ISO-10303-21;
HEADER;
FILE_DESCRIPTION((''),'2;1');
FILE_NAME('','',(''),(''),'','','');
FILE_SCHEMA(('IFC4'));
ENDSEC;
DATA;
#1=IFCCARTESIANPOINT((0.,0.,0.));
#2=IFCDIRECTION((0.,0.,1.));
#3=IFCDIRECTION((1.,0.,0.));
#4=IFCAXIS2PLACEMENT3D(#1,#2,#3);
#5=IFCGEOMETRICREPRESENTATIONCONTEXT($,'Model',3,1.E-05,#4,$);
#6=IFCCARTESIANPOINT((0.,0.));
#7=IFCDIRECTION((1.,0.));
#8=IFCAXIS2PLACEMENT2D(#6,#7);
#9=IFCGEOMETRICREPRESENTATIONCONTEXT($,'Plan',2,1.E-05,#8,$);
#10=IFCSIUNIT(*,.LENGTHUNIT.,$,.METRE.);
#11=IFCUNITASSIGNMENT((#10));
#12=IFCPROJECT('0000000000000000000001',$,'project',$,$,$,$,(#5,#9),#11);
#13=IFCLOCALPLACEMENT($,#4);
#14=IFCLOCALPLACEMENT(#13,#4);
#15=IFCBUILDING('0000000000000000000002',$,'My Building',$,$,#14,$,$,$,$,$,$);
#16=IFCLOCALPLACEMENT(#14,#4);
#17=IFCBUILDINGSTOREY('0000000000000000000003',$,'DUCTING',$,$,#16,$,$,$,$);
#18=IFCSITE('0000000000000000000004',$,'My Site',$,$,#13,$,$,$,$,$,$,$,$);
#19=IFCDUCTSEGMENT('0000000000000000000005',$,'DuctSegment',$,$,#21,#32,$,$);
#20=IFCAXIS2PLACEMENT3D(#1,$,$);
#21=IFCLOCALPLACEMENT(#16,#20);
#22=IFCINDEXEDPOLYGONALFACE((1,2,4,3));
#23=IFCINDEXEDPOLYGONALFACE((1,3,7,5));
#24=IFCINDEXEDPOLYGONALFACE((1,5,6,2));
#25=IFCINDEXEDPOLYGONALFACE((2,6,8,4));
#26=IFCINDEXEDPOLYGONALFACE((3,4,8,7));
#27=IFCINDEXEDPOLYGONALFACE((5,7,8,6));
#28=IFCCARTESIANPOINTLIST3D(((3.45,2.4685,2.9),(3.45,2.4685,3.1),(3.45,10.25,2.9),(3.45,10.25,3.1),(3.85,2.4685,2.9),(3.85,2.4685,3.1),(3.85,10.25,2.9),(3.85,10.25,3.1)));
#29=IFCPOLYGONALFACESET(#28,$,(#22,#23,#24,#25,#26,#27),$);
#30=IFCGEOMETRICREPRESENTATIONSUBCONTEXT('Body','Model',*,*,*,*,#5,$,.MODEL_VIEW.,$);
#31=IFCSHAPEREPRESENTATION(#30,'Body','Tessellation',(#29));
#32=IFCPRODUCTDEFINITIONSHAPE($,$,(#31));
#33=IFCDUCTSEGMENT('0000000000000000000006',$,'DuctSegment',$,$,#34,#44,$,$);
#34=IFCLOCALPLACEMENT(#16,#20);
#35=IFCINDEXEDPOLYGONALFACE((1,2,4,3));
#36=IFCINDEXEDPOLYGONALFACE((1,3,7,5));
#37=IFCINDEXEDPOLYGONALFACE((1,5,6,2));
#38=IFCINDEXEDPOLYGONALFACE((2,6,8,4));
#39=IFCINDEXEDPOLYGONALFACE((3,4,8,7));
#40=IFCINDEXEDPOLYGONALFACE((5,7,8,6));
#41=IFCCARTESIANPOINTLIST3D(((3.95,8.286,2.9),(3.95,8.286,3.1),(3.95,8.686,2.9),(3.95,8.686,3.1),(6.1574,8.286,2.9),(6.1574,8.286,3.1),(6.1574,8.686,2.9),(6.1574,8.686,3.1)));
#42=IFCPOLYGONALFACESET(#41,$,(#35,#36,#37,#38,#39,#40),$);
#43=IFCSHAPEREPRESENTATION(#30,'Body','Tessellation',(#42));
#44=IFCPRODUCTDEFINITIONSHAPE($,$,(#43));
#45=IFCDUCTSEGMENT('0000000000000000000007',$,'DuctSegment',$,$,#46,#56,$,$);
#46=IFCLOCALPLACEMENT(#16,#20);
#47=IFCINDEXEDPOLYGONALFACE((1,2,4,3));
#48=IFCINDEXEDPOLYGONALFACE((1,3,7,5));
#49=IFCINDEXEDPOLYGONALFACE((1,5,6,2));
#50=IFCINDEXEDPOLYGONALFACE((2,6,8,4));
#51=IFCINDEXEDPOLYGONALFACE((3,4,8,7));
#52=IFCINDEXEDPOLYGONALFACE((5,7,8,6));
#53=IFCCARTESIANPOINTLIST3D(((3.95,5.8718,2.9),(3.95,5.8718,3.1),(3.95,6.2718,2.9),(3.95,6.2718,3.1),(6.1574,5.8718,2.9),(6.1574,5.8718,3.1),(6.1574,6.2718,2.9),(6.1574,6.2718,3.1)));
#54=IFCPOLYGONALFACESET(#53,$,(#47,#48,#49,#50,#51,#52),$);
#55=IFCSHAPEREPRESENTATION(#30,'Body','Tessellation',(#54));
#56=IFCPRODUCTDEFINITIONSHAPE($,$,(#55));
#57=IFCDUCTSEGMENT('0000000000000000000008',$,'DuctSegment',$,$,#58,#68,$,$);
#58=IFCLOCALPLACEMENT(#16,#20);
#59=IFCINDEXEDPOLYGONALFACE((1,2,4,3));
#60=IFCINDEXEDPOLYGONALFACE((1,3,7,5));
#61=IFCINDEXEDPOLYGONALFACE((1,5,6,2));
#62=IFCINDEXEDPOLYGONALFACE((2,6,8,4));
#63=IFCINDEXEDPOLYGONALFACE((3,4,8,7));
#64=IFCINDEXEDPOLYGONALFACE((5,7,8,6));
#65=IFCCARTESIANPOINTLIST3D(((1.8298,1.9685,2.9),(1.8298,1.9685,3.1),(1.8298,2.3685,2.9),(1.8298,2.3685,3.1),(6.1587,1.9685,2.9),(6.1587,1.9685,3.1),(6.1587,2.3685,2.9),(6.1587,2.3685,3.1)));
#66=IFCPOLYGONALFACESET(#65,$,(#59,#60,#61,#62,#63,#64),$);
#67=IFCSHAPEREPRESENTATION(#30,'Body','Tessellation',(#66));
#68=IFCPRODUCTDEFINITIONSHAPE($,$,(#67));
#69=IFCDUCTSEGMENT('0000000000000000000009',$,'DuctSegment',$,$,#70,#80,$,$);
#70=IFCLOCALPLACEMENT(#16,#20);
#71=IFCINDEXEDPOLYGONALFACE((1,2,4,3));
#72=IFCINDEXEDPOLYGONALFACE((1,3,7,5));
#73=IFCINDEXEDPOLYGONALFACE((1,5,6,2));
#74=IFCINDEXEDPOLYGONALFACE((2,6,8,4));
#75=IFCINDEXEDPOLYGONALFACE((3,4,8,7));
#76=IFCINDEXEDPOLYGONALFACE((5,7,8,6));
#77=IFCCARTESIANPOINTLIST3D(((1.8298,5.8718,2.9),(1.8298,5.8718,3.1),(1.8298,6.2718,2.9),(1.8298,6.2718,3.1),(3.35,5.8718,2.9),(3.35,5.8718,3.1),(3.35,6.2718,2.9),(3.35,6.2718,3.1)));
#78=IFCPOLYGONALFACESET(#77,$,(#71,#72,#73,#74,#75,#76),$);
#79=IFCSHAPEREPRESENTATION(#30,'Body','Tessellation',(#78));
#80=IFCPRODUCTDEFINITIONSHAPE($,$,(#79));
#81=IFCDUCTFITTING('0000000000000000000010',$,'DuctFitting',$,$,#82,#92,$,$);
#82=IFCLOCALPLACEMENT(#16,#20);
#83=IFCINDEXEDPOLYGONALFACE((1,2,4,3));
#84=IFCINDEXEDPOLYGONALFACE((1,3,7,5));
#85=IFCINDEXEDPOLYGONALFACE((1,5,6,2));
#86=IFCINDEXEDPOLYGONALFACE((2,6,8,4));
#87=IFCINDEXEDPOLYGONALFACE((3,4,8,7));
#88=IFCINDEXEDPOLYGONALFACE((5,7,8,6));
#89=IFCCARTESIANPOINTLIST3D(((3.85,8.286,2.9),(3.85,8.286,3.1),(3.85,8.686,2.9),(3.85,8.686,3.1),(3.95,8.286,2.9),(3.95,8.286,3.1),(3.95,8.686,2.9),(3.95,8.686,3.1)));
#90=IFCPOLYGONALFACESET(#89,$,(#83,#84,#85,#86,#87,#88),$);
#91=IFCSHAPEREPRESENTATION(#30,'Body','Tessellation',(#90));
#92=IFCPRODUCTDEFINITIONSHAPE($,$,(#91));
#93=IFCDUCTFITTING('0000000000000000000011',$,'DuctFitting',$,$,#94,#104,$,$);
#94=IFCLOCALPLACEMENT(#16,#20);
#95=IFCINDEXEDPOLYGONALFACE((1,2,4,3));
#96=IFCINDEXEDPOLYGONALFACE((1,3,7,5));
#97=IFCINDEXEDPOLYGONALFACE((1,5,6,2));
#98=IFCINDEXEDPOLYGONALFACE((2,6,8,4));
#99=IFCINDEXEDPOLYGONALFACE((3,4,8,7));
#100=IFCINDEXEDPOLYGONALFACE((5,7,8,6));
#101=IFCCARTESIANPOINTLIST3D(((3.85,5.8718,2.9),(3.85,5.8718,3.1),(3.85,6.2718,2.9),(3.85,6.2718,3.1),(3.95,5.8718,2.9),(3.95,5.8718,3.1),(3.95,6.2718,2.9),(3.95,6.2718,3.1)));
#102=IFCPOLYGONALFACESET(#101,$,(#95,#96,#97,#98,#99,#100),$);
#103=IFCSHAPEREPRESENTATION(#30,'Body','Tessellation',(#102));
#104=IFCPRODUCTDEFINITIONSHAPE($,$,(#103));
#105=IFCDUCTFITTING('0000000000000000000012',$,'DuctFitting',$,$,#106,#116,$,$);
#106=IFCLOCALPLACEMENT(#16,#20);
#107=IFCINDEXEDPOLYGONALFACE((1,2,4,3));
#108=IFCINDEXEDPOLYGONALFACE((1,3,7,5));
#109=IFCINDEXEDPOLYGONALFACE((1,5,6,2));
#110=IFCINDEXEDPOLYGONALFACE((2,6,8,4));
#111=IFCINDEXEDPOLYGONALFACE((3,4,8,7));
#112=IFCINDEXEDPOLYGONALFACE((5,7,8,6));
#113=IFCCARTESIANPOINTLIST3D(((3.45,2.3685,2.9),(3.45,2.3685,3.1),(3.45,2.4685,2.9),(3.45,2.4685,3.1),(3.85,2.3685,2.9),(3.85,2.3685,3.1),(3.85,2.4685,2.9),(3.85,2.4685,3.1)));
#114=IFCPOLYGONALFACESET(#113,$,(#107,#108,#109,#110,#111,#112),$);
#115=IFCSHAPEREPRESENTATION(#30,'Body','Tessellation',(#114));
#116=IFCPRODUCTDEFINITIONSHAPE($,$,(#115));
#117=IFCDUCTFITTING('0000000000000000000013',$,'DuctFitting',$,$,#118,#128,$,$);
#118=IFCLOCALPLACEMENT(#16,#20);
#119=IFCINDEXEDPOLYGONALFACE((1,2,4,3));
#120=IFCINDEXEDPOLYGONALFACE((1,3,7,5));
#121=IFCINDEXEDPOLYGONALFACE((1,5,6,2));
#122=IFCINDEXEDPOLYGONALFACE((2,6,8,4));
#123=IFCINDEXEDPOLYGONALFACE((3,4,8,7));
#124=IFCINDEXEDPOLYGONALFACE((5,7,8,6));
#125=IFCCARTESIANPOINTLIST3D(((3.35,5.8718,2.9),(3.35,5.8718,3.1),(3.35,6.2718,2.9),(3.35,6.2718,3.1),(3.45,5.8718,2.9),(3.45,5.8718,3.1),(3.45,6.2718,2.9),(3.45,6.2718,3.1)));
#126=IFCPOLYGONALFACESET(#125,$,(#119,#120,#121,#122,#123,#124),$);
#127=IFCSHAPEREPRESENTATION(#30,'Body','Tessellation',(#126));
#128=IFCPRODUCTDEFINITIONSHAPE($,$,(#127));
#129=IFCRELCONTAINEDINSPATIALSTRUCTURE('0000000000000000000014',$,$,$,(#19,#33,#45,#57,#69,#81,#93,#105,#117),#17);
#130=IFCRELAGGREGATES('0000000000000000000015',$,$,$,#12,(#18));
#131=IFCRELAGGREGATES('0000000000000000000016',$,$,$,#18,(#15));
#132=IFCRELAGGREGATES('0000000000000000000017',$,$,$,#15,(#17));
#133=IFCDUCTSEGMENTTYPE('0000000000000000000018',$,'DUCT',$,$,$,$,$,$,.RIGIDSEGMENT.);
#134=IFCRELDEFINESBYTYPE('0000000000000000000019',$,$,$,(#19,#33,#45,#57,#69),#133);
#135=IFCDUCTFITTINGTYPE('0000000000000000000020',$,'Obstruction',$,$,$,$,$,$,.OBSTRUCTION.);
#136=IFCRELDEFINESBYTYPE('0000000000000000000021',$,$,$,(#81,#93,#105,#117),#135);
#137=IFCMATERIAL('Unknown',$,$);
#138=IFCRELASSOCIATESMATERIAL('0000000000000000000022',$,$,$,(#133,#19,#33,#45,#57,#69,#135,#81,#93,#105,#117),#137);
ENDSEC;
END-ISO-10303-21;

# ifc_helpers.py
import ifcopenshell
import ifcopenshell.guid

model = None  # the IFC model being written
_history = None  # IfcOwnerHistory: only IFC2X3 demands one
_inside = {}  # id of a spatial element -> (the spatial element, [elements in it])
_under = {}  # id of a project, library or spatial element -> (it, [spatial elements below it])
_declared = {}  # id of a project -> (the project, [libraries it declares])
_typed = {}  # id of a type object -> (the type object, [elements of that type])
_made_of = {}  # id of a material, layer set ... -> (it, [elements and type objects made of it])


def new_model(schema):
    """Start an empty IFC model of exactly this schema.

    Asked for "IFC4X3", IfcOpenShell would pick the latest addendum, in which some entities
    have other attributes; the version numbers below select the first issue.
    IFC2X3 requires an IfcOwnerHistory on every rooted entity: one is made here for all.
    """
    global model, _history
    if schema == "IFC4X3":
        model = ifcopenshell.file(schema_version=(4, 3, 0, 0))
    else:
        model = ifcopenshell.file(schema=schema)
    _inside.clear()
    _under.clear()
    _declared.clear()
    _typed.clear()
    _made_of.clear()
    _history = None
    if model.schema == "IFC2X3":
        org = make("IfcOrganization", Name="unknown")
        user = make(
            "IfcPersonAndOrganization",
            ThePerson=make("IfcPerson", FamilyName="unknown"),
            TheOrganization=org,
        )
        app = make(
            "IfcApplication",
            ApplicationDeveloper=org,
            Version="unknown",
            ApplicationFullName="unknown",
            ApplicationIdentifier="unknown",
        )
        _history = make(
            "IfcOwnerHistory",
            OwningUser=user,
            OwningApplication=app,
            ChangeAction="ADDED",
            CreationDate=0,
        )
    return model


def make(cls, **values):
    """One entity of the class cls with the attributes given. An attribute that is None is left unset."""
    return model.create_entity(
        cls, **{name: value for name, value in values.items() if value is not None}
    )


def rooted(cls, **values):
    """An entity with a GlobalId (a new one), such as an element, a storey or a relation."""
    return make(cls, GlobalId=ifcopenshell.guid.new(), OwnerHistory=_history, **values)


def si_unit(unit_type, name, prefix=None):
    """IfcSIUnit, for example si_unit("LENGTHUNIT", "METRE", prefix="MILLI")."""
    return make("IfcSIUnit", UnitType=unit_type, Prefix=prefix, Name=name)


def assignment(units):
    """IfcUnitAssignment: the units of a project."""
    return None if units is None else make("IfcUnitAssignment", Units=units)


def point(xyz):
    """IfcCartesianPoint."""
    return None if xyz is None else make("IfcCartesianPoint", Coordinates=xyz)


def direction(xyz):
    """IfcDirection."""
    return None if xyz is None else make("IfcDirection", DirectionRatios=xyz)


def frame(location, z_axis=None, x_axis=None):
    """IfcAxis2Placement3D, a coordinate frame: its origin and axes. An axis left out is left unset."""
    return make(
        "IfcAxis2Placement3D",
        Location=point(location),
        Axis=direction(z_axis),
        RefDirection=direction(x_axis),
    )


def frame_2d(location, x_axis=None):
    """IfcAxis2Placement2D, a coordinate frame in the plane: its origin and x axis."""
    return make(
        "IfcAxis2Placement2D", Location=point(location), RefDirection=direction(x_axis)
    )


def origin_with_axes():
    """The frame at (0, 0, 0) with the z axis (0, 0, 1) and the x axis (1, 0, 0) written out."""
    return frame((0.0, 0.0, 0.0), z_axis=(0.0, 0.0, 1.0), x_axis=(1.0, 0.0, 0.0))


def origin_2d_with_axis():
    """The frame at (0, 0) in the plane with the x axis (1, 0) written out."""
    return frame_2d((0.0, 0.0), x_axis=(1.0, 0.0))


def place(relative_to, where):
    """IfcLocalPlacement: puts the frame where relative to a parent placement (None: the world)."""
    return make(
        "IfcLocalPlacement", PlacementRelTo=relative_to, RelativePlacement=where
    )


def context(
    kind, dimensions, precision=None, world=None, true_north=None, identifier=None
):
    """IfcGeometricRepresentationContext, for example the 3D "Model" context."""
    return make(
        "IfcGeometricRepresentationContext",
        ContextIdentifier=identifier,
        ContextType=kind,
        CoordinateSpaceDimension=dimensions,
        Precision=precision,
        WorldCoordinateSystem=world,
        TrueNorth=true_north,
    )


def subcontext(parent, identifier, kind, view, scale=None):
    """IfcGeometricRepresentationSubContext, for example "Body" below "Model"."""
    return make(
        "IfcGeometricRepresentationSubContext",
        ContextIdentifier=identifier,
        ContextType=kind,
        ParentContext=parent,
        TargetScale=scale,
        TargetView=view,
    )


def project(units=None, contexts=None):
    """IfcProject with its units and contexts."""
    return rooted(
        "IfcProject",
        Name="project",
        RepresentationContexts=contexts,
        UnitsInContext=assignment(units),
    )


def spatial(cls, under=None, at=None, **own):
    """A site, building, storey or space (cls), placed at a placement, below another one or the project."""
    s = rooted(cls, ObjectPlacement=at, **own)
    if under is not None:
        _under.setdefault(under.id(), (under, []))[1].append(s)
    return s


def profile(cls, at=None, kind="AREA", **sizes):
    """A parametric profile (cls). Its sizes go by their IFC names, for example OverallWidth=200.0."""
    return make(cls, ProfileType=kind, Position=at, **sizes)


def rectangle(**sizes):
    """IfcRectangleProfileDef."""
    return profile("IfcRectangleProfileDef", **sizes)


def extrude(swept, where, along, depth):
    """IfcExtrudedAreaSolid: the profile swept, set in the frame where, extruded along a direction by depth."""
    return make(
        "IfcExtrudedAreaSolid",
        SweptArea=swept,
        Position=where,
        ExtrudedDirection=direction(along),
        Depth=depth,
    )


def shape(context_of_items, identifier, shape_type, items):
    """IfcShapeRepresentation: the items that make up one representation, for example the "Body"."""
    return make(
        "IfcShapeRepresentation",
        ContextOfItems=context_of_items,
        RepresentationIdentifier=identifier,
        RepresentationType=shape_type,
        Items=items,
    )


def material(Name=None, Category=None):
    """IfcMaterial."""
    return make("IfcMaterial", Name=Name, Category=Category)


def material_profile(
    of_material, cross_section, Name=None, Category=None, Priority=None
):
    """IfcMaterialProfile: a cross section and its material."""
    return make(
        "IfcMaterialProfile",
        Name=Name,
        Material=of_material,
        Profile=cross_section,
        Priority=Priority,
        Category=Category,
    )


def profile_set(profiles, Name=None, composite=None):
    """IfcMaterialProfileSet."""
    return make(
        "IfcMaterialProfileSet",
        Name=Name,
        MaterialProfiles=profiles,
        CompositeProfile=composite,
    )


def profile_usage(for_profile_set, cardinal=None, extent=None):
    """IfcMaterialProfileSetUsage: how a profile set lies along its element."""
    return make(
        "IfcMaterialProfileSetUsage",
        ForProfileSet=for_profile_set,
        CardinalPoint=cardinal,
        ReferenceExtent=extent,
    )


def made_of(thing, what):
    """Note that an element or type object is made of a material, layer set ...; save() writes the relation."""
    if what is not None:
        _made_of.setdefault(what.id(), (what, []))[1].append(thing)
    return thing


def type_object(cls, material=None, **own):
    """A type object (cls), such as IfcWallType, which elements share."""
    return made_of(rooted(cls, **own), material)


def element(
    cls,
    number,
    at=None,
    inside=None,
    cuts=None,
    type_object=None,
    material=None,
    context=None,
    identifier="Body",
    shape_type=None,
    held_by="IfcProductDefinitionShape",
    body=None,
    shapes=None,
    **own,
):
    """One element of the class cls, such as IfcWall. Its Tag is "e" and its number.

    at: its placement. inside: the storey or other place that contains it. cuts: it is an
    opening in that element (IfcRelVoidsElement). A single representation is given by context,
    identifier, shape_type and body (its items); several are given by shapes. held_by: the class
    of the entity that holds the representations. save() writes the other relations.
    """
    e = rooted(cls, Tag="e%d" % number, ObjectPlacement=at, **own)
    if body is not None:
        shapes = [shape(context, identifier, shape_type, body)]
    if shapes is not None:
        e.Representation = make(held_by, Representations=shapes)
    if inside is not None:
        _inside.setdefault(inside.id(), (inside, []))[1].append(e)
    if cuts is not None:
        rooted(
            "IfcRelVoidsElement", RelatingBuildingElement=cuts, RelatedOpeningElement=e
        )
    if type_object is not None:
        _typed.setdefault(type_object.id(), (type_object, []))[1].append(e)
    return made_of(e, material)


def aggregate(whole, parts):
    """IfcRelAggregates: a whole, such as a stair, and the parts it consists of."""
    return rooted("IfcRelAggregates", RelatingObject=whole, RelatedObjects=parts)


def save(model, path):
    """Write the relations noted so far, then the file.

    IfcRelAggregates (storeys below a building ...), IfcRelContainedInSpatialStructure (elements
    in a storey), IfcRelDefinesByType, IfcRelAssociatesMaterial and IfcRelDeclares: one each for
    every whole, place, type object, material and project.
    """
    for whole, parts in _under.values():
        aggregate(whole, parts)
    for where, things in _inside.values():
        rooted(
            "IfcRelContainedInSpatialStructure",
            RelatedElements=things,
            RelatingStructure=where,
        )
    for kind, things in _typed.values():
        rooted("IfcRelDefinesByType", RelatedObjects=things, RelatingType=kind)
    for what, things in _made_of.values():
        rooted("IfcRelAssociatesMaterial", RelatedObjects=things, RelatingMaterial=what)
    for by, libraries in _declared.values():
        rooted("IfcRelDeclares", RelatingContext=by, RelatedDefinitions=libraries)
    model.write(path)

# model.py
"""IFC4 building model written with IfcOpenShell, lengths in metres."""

from ifc_helpers import new_model, si_unit, frame, origin_with_axes, origin_2d_with_axis, place, context, subcontext, project, spatial, rectangle, extrude, material, material_profile, profile_set, profile_usage, type_object, element, save


model = new_model("IFC4")

# Units and contexts
model_context = context("Model", 3, precision=1e-05, world=origin_with_axes())
plan_context = context("Plan", 2, precision=1e-05, world=origin_2d_with_axis())
body_context = subcontext(model_context, "Body", "Model", "MODEL_VIEW")
ifc_project = project(units=[si_unit("LENGTHUNIT", "METRE")], contexts=[model_context, plan_context])

# Site, building, storey
site_placement = place(None, origin_with_axes())
site = spatial("IfcSite", under=ifc_project, at=site_placement, Name="My Site")
building_placement = place(site_placement, origin_with_axes())
building = spatial("IfcBuilding", under=site, at=building_placement, Name="My Building")
storey_placement = place(building_placement, origin_with_axes())
storey = spatial("IfcBuildingStorey", under=building, at=storey_placement, Name="DUCTING")

# Duct segments
ifc_material = material(Name="Unknown")
ifc_material_profile_1 = material_profile(ifc_material, rectangle(XDim=0.4, YDim=0.2))
ifc_profile_set_1 = profile_set([ifc_material_profile_1])
ifc_profile_usage_1 = profile_usage(ifc_profile_set_1, cardinal=5)
duct_segment_type = type_object("IfcDuctSegmentType", Name="DUCT", PredefinedType="RIGIDSEGMENT", material=ifc_profile_set_1)
duct_segment_1_placement = place(storey_placement, frame((3.65, 10.25, 3.0), z_axis=(0.0, -1.0, 0.0), x_axis=(1.0, 0.0, 0.0)))
element("IfcDuctSegment", 1, at=duct_segment_1_placement, inside=storey, type_object=duct_segment_type, material=ifc_profile_usage_1, Name="DuctSegment", context=body_context, shape_type="SweptSolid", body=[
    extrude(rectangle(XDim=0.4, YDim=0.2), origin_with_axes(), (0.0, 0.0, 1.0), 7.7815),
])
ifc_profile_usage_2 = profile_usage(ifc_profile_set_1, cardinal=5)
duct_segment_2_placement = place(storey_placement, frame((6.1574, 8.486, 3.0), z_axis=(-1.0, -0.000001, 0.000001), x_axis=(0.000001, -1.0, 0.0)))
element("IfcDuctSegment", 2, at=duct_segment_2_placement, inside=storey, type_object=duct_segment_type, material=ifc_profile_usage_2, Name="DuctSegment", context=body_context, shape_type="SweptSolid", body=[
    extrude(rectangle(XDim=0.4, YDim=0.2), origin_with_axes(), (0.0, 0.0, 1.0), 2.2074),
])
ifc_profile_usage_3 = profile_usage(ifc_profile_set_1, cardinal=5)
duct_segment_3_placement = place(storey_placement, frame((6.1574, 6.0718, 3.0), z_axis=(-1.0, -0.000001, 0.000001), x_axis=(0.000001, -1.0, 0.0)))
element("IfcDuctSegment", 3, at=duct_segment_3_placement, inside=storey, type_object=duct_segment_type, material=ifc_profile_usage_3, Name="DuctSegment", context=body_context, shape_type="SweptSolid", body=[
    extrude(rectangle(XDim=0.4, YDim=0.2), origin_with_axes(), (0.0, 0.0, 1.0), 2.2074),
])
ifc_profile_usage_4 = profile_usage(ifc_profile_set_1, cardinal=5)
duct_segment_4_placement = place(storey_placement, frame((1.8298, 2.1685, 3.0), z_axis=(1.0, 0.0, 0.0), x_axis=(0.0, 1.0, 0.0)))
element("IfcDuctSegment", 4, at=duct_segment_4_placement, inside=storey, type_object=duct_segment_type, material=ifc_profile_usage_4, Name="DuctSegment", context=body_context, shape_type="SweptSolid", body=[
    extrude(rectangle(XDim=0.4, YDim=0.2), origin_with_axes(), (0.0, 0.0, 1.0), 4.3289),
])
ifc_profile_usage_5 = profile_usage(ifc_profile_set_1, cardinal=5)
duct_segment_5_placement = place(storey_placement, frame((1.8298, 6.0718, 3.0), z_axis=(1.0, 0.0, 0.0), x_axis=(0.0, 1.0, 0.0)))
element("IfcDuctSegment", 5, at=duct_segment_5_placement, inside=storey, type_object=duct_segment_type, material=ifc_profile_usage_5, Name="DuctSegment", context=body_context, shape_type="SweptSolid", body=[
    extrude(rectangle(XDim=0.4, YDim=0.2), origin_with_axes(), (0.0, 0.0, 1.0), 1.5202),
])

# Duct fittings
ifc_material_profile_2 = material_profile(ifc_material, rectangle(XDim=0.4, YDim=0.2))
ifc_profile_set_2 = profile_set([ifc_material_profile_2])
ifc_profile_usage_6 = profile_usage(ifc_profile_set_2, cardinal=5)
duct_fitting_type = type_object("IfcDuctFittingType", Name="Obstruction", PredefinedType="OBSTRUCTION", material=ifc_profile_set_2)
duct_fitting_1_placement = place(storey_placement, frame((3.95, 8.486, 3.0), z_axis=(-1.0, -0.000001, 0.0), x_axis=(0.000001, -1.0, 0.0)))
element("IfcDuctFitting", 6, at=duct_fitting_1_placement, inside=storey, type_object=duct_fitting_type, material=ifc_profile_usage_6, Name="DuctFitting", context=body_context, shape_type="SweptSolid", body=[
    extrude(rectangle(XDim=0.4, YDim=0.2), origin_with_axes(), (0.0, 0.0, 1.0), 0.1),
])
ifc_profile_usage_7 = profile_usage(ifc_profile_set_2, cardinal=5)
duct_fitting_2_placement = place(storey_placement, frame((3.95, 6.0718, 3.0), z_axis=(-1.0, -0.000001, 0.0), x_axis=(0.000001, -1.0, 0.0)))
element("IfcDuctFitting", 7, at=duct_fitting_2_placement, inside=storey, type_object=duct_fitting_type, material=ifc_profile_usage_7, Name="DuctFitting", context=body_context, shape_type="SweptSolid", body=[
    extrude(rectangle(XDim=0.4, YDim=0.2), origin_with_axes(), (0.0, 0.0, 1.0), 0.1),
])
ifc_profile_usage_8 = profile_usage(ifc_profile_set_2, cardinal=5)
duct_fitting_3_placement = place(storey_placement, frame((3.65, 2.4685, 3.0), z_axis=(0.0, -1.0, 0.0), x_axis=(1.0, 0.0, 0.0)))
element("IfcDuctFitting", 8, at=duct_fitting_3_placement, inside=storey, type_object=duct_fitting_type, material=ifc_profile_usage_8, Name="DuctFitting", context=body_context, shape_type="SweptSolid", body=[
    extrude(rectangle(XDim=0.4, YDim=0.2), origin_with_axes(), (0.0, 0.0, 1.0), 0.1),
])
ifc_profile_usage_9 = profile_usage(ifc_profile_set_2, cardinal=5)
duct_fitting_4_placement = place(storey_placement, frame((3.35, 6.0718, 3.0), z_axis=(1.0, 0.0, 0.0), x_axis=(0.0, 1.0, 0.0)))
element("IfcDuctFitting", 9, at=duct_fitting_4_placement, inside=storey, type_object=duct_fitting_type, material=ifc_profile_usage_9, Name="DuctFitting", context=body_context, shape_type="SweptSolid", body=[
    extrude(rectangle(XDim=0.4, YDim=0.2), origin_with_axes(), (0.0, 0.0, 1.0), 0.1),
])

save(model, "model.ifc")
